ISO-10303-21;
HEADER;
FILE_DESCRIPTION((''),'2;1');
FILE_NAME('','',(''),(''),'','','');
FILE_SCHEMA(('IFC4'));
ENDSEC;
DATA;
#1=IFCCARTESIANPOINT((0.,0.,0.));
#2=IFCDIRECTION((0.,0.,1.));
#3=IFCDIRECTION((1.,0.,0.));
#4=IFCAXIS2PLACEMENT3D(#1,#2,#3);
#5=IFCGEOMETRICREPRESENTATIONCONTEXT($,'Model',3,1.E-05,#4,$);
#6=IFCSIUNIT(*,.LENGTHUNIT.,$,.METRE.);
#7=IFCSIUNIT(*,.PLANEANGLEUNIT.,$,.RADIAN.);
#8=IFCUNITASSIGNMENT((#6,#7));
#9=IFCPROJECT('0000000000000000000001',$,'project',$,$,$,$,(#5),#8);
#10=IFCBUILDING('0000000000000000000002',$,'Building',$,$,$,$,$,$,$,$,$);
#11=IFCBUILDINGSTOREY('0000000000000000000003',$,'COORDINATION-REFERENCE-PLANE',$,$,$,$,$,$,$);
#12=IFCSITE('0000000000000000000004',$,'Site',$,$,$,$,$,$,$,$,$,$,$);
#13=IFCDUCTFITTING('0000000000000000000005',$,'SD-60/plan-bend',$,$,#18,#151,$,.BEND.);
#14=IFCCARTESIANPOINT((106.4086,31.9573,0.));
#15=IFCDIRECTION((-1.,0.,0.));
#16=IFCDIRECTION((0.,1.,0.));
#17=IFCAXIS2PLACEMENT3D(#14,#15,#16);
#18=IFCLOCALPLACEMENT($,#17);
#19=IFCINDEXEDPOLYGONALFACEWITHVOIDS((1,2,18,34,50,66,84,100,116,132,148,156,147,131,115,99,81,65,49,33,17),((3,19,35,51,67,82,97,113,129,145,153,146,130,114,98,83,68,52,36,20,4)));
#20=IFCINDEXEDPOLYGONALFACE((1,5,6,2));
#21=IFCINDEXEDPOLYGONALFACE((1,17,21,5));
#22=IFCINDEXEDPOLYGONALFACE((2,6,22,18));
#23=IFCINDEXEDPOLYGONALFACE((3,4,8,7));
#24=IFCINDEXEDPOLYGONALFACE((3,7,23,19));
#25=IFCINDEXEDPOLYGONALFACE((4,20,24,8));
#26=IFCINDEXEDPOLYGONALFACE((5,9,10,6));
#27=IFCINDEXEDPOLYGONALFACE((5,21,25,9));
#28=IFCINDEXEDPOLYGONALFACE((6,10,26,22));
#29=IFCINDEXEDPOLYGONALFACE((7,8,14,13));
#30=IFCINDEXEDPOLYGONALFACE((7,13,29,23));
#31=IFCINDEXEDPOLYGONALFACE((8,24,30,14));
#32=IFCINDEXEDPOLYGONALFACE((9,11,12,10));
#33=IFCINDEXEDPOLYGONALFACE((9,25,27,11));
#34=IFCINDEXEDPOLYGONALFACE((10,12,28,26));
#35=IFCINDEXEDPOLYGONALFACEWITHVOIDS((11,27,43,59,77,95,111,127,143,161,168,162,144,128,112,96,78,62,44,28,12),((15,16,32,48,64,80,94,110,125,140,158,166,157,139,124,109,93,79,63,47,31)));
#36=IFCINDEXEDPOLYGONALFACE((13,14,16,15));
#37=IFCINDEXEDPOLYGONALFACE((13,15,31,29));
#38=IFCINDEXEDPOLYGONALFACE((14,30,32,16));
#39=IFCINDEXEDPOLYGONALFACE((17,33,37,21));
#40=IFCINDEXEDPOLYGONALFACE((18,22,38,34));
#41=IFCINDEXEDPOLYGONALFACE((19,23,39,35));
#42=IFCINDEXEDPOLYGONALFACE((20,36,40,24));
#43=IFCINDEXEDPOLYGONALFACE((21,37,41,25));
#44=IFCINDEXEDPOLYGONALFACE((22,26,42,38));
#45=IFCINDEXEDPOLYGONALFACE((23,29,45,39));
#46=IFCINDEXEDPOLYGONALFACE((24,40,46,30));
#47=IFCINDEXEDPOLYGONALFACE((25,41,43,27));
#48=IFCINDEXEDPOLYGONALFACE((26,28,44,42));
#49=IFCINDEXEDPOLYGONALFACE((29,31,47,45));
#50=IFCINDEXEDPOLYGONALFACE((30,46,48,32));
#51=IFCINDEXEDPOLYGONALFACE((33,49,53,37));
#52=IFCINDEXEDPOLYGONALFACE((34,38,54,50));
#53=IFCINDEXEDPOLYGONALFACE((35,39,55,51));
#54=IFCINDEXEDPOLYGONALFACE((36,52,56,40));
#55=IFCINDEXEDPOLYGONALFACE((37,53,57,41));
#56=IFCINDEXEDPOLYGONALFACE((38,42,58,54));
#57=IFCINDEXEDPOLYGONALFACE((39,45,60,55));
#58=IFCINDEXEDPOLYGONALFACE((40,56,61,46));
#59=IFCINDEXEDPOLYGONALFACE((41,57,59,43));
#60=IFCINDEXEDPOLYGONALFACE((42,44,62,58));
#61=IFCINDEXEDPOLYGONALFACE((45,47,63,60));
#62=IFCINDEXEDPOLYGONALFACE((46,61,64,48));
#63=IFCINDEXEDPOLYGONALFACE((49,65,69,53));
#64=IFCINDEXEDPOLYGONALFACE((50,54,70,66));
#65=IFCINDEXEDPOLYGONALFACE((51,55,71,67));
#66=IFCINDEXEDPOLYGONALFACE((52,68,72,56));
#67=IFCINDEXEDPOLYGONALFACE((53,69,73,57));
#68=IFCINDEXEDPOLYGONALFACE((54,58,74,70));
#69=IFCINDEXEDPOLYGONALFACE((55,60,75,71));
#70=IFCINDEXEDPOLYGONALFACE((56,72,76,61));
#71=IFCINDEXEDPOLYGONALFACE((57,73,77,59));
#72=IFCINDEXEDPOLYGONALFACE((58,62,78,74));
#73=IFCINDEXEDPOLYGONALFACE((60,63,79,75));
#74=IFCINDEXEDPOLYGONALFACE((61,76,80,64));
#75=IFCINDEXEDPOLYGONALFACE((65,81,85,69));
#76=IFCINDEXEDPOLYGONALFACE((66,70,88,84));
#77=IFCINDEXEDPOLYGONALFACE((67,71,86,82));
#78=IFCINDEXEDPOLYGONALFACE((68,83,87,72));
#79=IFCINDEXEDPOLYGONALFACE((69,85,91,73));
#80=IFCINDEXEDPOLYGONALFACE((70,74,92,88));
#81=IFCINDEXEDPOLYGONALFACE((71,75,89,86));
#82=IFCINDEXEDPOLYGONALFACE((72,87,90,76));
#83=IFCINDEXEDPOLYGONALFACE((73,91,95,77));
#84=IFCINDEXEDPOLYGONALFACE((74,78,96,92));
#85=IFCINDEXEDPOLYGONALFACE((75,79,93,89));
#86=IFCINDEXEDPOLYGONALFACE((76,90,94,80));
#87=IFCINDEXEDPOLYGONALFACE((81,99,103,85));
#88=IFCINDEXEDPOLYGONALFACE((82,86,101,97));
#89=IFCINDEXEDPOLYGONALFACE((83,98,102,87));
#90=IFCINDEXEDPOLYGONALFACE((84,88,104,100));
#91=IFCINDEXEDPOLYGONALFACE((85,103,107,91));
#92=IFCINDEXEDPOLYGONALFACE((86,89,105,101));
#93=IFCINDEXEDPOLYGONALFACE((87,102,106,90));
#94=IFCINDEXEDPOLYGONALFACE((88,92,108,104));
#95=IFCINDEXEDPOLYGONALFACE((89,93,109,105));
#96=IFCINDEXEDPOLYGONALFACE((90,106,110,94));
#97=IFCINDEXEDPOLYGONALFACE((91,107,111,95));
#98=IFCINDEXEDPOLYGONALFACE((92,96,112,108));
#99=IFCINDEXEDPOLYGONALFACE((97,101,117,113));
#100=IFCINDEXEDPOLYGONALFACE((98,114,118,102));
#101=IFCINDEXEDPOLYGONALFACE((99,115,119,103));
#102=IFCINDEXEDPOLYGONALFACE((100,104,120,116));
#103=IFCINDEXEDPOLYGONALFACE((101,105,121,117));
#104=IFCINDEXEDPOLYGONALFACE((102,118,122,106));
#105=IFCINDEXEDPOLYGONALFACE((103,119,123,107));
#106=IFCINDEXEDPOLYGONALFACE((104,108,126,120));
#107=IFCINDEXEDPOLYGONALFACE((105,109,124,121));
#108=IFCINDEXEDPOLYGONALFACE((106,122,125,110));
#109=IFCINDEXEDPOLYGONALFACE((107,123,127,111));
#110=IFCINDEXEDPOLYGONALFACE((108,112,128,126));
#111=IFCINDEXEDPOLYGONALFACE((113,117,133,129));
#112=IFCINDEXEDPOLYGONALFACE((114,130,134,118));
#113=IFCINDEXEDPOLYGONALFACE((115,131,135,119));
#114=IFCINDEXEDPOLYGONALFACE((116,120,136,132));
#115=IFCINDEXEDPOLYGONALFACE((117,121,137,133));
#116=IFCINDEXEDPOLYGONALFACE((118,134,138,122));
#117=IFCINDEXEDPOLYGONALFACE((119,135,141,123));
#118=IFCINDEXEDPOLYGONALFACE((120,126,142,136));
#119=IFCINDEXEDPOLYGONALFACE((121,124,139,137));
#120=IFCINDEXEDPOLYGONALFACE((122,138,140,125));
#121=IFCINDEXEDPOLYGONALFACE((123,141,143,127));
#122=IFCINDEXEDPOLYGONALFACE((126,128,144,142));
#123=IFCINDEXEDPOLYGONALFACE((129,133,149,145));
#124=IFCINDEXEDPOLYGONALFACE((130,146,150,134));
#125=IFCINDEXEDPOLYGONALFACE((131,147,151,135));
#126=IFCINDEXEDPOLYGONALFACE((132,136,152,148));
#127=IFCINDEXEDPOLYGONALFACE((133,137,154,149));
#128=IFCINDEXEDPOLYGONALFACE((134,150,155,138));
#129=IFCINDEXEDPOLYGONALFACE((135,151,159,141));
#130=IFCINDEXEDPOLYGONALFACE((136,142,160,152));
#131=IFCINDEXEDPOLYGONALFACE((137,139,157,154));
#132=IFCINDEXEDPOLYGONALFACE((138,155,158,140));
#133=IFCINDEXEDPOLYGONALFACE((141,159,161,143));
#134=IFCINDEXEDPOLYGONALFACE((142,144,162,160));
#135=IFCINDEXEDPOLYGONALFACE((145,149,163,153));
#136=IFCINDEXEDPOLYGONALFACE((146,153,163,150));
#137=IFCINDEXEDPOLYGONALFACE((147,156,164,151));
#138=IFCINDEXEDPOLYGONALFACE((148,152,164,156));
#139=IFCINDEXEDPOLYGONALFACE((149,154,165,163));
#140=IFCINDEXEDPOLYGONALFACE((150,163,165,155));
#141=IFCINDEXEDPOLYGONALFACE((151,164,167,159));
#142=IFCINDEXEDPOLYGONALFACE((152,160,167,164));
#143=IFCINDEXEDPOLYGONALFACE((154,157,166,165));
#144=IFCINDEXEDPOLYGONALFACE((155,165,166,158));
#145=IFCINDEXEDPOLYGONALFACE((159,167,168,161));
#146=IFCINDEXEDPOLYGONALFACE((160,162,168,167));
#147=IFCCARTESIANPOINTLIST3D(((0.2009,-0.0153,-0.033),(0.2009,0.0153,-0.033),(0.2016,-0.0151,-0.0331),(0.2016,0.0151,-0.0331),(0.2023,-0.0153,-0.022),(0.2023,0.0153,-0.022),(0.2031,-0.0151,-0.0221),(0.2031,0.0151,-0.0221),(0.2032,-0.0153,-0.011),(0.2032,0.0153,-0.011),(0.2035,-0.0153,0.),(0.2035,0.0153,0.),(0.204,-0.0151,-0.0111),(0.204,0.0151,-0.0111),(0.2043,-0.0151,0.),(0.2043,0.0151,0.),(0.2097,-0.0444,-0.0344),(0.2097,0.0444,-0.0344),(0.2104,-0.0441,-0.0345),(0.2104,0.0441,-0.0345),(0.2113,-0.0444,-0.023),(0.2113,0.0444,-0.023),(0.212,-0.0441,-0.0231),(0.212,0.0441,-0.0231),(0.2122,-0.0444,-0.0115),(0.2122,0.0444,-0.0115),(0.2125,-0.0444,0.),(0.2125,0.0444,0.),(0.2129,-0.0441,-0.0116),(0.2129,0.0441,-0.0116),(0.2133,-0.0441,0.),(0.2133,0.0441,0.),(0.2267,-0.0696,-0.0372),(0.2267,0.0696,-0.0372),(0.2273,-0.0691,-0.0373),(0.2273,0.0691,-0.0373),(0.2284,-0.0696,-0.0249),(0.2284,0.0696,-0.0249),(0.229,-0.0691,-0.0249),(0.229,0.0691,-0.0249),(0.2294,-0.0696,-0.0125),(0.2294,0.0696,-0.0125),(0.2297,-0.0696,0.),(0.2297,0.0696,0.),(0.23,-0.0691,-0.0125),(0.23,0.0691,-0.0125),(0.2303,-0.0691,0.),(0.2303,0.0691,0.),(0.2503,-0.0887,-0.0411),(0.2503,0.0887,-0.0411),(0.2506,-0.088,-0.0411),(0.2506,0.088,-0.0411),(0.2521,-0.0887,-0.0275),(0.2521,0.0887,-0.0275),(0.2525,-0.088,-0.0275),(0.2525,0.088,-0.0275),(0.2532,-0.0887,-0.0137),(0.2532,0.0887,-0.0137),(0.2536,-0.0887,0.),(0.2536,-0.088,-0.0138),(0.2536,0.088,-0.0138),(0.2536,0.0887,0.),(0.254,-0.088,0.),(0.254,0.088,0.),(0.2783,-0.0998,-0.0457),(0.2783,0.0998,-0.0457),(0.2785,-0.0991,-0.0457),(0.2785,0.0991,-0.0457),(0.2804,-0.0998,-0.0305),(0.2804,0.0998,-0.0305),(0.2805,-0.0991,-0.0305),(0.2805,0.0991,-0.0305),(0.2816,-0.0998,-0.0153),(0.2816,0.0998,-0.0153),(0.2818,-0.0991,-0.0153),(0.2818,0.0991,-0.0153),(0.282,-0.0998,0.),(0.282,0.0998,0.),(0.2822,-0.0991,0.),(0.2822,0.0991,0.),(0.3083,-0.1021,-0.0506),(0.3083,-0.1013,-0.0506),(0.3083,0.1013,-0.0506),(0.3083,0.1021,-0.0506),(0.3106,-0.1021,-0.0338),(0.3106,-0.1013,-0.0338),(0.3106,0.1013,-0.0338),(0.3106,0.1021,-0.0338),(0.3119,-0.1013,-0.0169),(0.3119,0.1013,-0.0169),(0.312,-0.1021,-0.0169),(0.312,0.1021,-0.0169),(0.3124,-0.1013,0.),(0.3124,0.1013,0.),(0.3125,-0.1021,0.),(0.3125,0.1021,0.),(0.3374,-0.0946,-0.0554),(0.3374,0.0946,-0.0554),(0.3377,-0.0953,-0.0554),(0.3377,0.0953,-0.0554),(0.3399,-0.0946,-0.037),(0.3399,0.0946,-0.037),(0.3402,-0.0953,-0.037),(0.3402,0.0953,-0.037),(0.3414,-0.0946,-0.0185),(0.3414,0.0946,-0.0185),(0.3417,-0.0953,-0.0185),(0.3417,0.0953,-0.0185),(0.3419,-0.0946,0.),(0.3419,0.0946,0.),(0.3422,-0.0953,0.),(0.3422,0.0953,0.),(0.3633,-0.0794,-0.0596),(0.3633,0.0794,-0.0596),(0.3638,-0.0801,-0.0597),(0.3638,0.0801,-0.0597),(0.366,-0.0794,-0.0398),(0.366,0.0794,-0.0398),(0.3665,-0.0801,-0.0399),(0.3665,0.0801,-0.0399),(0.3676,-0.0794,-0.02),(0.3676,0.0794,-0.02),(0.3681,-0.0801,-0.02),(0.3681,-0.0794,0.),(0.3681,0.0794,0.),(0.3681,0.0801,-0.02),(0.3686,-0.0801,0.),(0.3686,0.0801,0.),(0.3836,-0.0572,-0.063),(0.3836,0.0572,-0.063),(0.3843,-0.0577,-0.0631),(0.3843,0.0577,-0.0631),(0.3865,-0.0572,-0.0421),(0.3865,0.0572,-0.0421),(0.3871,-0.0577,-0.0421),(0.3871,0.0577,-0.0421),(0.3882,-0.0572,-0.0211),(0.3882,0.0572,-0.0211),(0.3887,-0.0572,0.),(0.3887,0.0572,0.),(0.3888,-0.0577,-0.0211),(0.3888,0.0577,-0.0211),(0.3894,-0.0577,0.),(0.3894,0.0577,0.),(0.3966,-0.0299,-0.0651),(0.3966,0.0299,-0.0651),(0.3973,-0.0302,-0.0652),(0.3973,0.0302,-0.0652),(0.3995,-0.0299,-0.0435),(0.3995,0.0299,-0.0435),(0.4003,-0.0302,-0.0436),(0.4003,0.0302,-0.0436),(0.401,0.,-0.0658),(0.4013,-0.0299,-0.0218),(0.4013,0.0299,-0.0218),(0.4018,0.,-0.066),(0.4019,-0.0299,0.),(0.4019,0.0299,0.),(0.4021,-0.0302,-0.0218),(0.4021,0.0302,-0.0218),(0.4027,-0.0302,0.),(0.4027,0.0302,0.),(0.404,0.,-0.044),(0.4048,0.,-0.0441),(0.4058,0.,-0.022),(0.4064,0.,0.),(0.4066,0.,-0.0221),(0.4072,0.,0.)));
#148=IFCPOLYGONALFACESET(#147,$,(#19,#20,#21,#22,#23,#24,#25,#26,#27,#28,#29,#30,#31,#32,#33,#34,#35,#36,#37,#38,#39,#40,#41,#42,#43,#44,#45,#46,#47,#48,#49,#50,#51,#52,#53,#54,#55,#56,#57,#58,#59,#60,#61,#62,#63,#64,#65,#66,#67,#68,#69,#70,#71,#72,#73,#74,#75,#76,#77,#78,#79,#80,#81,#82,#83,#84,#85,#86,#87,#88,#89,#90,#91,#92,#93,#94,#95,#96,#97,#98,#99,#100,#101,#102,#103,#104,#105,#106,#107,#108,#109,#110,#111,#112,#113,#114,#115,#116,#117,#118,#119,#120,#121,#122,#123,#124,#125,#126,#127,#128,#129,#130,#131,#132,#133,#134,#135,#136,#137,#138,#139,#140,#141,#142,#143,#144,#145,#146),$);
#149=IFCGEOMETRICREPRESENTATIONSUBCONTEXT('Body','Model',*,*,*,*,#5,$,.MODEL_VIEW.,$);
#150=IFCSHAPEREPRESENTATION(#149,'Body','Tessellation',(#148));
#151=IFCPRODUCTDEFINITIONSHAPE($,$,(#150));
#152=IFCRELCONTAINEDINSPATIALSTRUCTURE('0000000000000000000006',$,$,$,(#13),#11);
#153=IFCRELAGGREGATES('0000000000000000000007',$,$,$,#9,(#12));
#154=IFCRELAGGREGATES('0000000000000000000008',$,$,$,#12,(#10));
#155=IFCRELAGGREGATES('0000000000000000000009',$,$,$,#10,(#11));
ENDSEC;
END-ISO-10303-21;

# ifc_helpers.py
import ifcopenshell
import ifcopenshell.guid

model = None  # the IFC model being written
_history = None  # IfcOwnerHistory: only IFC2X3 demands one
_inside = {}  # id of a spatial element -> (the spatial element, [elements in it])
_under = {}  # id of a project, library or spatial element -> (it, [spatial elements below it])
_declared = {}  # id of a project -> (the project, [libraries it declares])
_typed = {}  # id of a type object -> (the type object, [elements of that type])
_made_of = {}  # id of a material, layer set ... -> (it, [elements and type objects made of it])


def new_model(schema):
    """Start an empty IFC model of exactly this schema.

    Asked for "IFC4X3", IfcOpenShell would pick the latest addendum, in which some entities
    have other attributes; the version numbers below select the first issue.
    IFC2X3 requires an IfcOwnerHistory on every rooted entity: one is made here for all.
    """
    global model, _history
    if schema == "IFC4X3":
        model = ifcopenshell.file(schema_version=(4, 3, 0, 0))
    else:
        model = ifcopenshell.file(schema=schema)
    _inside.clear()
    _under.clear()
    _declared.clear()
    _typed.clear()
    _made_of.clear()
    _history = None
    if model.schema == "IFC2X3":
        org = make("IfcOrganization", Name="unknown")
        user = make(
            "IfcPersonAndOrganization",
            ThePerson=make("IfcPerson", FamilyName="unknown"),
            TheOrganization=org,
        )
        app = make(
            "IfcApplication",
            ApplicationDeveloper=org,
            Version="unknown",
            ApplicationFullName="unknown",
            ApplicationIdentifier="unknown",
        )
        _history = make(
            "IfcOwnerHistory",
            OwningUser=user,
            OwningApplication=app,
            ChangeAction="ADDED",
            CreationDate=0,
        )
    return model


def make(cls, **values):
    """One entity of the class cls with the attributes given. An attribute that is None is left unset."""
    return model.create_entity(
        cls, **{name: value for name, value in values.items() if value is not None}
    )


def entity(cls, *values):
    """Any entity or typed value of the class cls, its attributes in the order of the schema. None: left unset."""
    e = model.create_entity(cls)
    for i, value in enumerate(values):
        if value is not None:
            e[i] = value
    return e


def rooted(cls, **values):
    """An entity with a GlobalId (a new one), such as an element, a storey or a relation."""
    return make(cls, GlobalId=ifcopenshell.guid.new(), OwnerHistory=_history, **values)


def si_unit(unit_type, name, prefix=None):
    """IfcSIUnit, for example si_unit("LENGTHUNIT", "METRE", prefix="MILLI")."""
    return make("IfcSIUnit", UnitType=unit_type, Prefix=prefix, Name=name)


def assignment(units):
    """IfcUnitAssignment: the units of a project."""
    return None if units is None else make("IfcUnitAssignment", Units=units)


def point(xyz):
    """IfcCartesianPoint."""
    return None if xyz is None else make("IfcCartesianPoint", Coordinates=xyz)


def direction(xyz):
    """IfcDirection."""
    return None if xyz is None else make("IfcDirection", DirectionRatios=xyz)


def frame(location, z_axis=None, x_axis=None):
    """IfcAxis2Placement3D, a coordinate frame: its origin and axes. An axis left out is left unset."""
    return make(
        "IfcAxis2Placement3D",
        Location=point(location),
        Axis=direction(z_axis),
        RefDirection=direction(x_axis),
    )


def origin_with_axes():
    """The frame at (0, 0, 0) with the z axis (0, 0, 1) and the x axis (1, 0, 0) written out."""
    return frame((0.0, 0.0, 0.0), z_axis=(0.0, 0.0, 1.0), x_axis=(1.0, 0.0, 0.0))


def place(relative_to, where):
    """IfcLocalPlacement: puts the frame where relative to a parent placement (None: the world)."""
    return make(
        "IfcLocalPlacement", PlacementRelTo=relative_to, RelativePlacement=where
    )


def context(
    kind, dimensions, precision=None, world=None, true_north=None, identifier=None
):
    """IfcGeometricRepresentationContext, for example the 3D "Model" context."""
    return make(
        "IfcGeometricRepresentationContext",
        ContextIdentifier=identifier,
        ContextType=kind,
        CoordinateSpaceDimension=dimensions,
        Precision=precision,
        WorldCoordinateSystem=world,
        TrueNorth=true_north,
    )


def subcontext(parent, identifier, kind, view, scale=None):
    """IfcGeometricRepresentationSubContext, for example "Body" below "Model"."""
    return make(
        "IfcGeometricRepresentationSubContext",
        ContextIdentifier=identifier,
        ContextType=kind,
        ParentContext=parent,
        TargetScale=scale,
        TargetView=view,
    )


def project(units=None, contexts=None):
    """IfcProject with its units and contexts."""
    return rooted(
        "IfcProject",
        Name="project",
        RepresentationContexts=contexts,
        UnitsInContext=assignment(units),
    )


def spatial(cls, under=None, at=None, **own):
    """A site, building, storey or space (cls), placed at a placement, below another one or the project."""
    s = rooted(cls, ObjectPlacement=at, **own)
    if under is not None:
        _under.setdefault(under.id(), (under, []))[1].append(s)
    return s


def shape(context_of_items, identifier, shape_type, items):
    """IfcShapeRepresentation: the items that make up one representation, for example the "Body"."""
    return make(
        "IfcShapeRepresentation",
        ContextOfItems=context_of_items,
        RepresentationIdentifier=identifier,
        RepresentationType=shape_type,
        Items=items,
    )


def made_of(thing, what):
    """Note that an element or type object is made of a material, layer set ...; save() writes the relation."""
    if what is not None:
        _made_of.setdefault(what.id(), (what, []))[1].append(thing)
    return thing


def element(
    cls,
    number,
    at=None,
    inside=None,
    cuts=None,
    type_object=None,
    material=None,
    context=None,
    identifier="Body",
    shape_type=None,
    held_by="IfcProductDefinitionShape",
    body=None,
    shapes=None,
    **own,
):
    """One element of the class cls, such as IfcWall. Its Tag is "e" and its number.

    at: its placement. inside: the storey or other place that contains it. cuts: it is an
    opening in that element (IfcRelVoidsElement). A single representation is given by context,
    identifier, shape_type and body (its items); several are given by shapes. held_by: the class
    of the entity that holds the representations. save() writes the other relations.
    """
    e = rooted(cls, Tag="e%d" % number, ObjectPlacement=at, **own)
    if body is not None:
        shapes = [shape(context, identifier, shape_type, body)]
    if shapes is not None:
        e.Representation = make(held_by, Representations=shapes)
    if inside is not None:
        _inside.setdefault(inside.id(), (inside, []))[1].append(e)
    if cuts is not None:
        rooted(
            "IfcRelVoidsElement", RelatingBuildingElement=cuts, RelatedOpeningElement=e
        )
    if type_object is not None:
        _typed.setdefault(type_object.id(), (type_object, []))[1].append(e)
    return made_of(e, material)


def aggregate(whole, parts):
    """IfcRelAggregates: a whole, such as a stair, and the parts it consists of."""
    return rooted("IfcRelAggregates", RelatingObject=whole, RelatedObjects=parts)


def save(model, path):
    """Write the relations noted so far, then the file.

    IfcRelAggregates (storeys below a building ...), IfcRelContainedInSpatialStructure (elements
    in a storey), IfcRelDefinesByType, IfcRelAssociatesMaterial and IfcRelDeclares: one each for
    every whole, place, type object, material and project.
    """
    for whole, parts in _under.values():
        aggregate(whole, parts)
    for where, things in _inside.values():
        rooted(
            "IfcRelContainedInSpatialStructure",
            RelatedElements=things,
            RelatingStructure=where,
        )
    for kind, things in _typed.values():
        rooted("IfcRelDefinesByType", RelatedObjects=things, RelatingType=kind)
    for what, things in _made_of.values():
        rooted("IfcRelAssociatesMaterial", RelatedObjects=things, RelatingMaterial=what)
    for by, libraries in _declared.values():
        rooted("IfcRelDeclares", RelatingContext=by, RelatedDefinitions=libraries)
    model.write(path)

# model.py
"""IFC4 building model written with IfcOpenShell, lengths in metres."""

from ifc_helpers import new_model, entity, si_unit, frame, origin_with_axes, place, context, subcontext, project, spatial, element, save


model = new_model("IFC4")

# Units and contexts
model_context = context("Model", 3, precision=1e-05, world=origin_with_axes())
body_context_1 = subcontext(model_context, "Body", "Model", "MODEL_VIEW")
ifc_project = project(units=[si_unit("LENGTHUNIT", "METRE"), si_unit("PLANEANGLEUNIT", "RADIAN")], contexts=[model_context])

# Site, building, storey
site = spatial("IfcSite", under=ifc_project, Name="Site")
building = spatial("IfcBuilding", under=site, Name="Building")
storey = spatial("IfcBuildingStorey", under=building, Name="COORDINATION-REFERENCE-PLANE")

# Duct fitting
duct_fitting_1_placement = place(None, frame((106.4086, 31.9573, 0.0), z_axis=(-1.0, 0.0, 0.0), x_axis=(0.0, 1.0, 0.0)))
element("IfcDuctFitting", 1, at=duct_fitting_1_placement, inside=storey, Name="SD-60/plan-bend", PredefinedType="BEND", context=body_context_1, shape_type="SweptSolid", body=[
    entity("IfcRevolvedAreaSolid", entity("IfcCircleHollowProfileDef", "AREA", None, entity("IfcAxis2Placement2D", entity("IfcCartesianPoint", [0.3048, 0.0])), 0.1024, 0.0008), entity("IfcAxis2Placement3D", entity("IfcCartesianPoint", [0.0, 0.0, 0.0]), entity("IfcDirection", [0.0, 0.0, 1.0]), entity("IfcDirection", [1.0, 0.0, 0.0])), entity("IfcAxis1Placement", entity("IfcCartesianPoint", [0.0, 0.0, 0.0]), entity("IfcDirection", [0.0, 1.0, 0.0])), 0.162681),
])

save(model, "model.ifc")
